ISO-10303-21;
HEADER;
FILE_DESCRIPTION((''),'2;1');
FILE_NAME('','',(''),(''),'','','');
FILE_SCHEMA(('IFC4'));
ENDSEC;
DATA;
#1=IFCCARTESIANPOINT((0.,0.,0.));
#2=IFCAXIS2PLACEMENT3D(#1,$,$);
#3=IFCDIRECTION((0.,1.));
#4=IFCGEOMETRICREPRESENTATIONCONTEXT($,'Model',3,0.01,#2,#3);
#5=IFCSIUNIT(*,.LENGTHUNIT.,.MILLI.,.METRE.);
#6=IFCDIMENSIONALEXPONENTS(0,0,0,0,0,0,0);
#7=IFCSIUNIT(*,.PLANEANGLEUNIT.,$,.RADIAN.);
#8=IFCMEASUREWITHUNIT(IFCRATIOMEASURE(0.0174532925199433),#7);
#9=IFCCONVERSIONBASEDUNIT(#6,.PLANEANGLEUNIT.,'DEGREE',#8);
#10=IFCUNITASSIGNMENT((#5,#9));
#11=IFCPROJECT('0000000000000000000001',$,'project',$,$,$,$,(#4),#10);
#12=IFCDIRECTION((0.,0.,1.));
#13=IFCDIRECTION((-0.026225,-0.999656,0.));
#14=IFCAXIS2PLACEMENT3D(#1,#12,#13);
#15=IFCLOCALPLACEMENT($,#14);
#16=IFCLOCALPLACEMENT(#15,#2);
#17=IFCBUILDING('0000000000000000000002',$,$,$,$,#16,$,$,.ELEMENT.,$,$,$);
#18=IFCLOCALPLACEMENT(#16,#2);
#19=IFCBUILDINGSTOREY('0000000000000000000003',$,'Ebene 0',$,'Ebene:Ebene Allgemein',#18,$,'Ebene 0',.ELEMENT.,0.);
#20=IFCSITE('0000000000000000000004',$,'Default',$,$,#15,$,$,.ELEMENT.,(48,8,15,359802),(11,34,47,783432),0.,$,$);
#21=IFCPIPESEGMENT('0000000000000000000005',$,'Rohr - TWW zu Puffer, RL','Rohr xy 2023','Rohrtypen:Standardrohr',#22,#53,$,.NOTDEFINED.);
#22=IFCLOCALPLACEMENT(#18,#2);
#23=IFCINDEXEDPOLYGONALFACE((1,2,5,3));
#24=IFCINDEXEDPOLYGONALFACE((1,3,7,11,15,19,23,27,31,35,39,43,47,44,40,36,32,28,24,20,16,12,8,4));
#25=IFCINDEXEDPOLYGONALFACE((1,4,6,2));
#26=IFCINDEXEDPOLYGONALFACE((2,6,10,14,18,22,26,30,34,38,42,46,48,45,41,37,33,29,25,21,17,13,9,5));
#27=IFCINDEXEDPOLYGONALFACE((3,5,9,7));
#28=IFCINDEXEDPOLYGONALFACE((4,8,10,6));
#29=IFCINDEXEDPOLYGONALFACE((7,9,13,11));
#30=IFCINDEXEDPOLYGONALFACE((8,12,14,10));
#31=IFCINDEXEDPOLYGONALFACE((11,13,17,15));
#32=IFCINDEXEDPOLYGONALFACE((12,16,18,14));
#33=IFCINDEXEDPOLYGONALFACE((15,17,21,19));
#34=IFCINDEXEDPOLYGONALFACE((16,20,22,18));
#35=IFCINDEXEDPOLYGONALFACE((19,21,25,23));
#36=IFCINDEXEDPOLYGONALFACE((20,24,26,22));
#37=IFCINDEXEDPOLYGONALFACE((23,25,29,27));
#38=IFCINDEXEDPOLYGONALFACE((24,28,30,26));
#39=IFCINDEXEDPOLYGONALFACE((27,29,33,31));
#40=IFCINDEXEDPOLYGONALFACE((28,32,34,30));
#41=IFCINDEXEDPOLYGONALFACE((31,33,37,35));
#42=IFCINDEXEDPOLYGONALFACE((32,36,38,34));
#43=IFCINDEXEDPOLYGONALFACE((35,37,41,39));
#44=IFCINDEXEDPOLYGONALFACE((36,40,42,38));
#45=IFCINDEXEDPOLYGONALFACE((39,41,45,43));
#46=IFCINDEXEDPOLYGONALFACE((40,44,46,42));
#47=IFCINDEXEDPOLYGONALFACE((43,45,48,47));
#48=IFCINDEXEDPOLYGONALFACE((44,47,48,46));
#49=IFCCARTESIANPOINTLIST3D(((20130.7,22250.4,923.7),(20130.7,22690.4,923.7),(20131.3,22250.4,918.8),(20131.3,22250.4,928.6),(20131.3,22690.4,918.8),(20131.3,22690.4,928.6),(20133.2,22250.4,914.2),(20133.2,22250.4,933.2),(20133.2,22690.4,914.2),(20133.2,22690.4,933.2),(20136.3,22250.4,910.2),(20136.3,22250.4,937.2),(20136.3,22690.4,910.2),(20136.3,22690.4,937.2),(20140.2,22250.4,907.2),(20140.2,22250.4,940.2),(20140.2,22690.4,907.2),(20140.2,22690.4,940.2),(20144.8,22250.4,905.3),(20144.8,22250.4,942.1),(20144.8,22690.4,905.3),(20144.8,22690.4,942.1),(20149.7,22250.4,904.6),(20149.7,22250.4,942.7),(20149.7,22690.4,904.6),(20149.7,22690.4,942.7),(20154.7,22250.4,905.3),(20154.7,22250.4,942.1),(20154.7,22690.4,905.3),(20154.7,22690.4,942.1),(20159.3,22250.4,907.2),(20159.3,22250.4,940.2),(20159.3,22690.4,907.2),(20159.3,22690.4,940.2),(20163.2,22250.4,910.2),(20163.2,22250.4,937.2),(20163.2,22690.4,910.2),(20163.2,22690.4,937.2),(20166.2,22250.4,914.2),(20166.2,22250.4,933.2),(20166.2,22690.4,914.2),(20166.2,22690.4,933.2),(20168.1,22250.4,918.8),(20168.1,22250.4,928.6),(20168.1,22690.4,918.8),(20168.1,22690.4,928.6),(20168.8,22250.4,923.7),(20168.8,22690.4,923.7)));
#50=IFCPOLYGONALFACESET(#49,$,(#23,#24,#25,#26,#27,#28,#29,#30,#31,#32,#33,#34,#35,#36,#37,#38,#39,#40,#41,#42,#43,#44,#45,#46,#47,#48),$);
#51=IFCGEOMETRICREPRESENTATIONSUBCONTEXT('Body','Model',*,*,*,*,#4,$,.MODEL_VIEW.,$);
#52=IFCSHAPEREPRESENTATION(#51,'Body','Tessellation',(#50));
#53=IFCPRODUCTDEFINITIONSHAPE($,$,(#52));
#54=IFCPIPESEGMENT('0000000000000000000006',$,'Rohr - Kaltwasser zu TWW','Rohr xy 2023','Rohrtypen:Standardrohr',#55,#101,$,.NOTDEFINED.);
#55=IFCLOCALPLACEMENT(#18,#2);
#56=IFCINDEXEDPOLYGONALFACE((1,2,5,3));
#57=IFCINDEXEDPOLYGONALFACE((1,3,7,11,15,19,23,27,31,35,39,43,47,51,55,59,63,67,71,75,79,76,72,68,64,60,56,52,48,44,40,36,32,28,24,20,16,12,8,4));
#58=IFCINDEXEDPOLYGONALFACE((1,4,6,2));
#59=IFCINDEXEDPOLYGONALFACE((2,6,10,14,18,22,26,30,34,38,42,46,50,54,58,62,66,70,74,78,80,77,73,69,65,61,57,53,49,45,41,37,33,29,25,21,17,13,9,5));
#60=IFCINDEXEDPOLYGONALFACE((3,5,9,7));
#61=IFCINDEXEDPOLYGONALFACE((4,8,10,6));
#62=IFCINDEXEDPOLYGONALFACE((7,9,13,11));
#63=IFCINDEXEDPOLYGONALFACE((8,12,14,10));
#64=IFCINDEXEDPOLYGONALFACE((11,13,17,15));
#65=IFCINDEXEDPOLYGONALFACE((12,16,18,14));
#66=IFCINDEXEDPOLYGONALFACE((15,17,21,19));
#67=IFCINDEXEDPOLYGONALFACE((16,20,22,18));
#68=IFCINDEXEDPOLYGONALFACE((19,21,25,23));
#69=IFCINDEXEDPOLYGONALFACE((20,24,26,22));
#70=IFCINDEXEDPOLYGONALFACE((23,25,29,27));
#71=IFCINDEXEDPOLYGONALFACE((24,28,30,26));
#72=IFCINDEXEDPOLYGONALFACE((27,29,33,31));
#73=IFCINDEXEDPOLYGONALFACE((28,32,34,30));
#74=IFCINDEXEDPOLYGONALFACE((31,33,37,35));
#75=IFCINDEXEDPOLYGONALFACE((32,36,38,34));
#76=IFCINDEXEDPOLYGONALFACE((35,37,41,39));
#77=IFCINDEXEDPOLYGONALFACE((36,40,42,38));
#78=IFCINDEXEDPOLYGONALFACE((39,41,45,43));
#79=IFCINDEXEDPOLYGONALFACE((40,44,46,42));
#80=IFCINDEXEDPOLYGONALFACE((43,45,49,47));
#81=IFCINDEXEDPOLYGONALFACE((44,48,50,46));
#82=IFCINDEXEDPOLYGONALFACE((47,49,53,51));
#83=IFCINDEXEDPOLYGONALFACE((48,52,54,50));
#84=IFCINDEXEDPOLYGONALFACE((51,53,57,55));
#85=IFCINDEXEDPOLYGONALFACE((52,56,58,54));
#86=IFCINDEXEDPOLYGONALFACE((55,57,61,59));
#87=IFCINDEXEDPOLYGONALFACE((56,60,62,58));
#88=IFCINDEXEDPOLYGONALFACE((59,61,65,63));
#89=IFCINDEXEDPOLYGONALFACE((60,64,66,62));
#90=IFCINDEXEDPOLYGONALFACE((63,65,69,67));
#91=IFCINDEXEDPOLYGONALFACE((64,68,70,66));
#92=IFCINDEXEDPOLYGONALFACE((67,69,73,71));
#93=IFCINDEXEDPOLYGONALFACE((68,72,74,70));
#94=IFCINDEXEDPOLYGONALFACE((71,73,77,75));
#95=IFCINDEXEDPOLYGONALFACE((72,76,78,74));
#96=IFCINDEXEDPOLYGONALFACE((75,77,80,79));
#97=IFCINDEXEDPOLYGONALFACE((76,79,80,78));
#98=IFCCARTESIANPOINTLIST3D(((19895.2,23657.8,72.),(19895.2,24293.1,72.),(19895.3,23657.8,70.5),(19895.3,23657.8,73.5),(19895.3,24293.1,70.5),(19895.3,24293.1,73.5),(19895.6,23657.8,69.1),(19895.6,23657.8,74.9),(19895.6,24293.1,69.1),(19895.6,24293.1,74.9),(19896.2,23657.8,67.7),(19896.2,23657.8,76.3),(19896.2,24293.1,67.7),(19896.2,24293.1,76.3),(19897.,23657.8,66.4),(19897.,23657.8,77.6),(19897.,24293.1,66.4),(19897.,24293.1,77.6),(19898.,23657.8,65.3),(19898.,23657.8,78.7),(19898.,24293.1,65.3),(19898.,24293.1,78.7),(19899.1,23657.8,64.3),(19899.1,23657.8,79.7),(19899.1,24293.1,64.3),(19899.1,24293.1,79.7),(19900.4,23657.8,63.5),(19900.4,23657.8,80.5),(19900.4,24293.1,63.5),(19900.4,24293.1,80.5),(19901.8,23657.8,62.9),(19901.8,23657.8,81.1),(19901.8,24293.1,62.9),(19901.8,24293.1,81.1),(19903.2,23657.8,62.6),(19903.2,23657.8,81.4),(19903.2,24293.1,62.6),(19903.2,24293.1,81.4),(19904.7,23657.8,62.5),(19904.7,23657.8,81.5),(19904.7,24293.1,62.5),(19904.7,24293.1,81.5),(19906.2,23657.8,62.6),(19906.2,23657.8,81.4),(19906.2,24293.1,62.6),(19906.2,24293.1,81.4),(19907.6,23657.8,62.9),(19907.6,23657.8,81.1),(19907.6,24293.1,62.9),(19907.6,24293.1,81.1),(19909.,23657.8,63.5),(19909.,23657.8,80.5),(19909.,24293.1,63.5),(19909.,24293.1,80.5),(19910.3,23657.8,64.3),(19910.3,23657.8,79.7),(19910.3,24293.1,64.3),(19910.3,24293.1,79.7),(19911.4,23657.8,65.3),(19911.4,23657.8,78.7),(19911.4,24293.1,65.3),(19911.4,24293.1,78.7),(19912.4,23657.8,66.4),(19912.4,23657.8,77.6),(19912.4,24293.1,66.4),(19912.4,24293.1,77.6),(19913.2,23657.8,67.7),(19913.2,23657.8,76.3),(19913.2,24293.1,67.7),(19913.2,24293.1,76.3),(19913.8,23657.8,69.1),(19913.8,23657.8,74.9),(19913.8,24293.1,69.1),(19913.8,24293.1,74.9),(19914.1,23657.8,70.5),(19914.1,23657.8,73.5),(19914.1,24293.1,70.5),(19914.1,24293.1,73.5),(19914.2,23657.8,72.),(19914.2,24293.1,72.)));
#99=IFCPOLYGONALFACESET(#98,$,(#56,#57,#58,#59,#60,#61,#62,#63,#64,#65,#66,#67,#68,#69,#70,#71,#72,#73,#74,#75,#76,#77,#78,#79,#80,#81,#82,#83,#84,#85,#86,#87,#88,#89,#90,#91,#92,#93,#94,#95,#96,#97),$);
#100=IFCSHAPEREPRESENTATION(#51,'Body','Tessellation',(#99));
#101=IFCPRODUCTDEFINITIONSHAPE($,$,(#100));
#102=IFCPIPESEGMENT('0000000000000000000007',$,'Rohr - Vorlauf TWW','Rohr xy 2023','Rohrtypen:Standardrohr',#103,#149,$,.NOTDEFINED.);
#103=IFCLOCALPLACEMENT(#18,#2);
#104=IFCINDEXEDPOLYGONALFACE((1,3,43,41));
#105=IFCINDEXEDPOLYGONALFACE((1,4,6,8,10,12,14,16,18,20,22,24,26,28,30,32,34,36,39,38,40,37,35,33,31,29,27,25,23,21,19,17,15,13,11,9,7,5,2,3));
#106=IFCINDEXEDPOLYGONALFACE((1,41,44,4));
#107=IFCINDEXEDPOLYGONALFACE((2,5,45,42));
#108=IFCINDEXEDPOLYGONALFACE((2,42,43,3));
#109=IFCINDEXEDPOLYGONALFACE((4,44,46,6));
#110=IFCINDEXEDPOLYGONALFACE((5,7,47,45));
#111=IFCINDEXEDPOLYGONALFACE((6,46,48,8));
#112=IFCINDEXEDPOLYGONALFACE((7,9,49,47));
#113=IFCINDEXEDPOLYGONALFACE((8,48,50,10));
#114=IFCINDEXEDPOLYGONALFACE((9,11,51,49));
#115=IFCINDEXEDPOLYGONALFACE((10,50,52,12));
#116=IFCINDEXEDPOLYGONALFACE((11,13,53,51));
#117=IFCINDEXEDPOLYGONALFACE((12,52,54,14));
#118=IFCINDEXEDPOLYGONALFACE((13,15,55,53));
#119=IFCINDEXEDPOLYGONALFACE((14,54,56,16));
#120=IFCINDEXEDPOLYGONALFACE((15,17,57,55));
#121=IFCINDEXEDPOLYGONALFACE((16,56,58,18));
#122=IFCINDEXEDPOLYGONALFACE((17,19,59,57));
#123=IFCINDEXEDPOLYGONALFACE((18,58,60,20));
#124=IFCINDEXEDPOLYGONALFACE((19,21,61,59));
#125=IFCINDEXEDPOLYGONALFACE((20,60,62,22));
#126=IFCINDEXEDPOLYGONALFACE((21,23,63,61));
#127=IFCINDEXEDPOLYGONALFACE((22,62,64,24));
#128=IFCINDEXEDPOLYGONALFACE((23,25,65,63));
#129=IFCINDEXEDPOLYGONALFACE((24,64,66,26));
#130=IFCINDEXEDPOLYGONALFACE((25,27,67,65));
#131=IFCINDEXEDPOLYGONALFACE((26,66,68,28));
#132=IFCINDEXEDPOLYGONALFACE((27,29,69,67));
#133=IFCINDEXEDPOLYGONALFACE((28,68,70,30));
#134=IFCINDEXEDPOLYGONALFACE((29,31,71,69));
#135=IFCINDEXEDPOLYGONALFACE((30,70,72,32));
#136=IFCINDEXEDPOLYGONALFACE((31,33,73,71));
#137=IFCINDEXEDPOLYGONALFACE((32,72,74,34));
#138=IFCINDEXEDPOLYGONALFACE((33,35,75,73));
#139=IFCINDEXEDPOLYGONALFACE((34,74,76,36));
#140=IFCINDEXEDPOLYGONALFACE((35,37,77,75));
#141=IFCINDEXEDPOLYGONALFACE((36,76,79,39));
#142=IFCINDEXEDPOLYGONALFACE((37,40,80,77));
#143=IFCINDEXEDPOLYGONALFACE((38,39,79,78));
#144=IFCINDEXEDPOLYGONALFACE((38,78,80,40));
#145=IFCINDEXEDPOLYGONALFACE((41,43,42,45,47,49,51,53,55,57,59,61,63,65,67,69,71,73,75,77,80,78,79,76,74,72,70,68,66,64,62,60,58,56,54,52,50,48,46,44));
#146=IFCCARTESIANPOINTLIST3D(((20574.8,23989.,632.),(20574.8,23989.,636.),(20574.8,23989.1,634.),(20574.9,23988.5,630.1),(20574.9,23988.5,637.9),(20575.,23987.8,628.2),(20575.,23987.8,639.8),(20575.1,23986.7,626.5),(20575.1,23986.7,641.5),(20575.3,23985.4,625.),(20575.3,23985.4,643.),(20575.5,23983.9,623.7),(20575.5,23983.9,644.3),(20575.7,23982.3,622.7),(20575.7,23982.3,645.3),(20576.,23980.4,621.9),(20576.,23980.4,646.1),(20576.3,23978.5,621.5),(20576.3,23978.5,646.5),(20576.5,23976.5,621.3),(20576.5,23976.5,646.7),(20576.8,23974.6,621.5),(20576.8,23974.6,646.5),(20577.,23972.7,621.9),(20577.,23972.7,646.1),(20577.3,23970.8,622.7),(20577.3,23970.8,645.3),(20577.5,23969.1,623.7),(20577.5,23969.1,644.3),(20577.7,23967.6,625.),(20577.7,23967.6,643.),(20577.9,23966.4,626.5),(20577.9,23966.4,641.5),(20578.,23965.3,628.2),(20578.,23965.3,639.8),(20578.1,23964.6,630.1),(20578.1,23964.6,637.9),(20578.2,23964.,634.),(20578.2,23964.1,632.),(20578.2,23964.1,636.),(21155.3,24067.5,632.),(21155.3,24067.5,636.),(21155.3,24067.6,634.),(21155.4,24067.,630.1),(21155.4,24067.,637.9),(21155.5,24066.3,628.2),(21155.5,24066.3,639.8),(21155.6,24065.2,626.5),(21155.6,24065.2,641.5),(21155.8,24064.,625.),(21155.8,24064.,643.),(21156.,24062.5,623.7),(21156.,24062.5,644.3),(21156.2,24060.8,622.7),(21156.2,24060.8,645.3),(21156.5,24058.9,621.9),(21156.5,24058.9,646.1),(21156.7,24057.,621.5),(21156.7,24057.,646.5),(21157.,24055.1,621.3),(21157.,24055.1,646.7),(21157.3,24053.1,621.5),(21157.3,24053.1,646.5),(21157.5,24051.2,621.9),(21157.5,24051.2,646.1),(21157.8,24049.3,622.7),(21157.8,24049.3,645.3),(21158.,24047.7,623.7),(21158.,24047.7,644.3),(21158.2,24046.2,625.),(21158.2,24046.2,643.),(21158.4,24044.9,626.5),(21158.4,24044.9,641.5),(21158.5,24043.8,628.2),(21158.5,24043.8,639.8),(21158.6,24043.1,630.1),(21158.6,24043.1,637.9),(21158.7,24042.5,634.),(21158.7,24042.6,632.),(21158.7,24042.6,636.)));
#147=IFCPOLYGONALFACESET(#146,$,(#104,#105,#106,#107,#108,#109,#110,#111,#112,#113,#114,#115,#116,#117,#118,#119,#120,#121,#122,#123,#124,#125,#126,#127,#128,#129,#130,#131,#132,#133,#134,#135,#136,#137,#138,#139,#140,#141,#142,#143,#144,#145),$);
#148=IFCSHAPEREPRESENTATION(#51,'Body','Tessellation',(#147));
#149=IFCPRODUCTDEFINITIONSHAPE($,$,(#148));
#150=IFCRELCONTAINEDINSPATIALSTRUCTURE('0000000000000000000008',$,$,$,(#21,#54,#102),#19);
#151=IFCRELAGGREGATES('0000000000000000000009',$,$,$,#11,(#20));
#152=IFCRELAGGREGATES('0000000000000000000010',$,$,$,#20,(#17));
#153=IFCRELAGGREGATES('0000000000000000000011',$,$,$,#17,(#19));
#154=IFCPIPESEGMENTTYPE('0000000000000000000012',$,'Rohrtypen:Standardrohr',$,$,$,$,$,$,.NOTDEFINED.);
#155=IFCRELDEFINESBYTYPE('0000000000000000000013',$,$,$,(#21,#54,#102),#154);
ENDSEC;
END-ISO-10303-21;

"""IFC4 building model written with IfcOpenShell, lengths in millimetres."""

from ifc_helpers import new_model, entity, si_unit, converted_unit, direction, frame, origin, place, context, subcontext, project, spatial, indexed_curve, outline, extrude, type_object, element, save


model = new_model("IFC4")

# Units and contexts
model_context = context("Model", 3, precision=0.01, world=origin(), true_north=direction((0.0, 1.0)))
body_context = subcontext(model_context, "Body", "Model", "MODEL_VIEW")
ifc_project = project(units=[si_unit("LENGTHUNIT", "METRE", prefix="MILLI"), converted_unit("PLANEANGLEUNIT", "DEGREE", entity("IfcRatioMeasure", 0.0174532925199433), si_unit("PLANEANGLEUNIT", "RADIAN"), dimensions=[0, 0, 0, 0, 0, 0, 0])], contexts=[model_context])

# Site, building, storey
site_placement = place(None, frame((0.0, 0.0, 0.0), z_axis=(0.0, 0.0, 1.0), x_axis=(-0.026225, -0.999656, 0.0)))
site = spatial("IfcSite", under=ifc_project, at=site_placement, Name="Default", CompositionType="ELEMENT", RefLatitude=(48, 8, 15, 359802), RefLongitude=(11, 34, 47, 783432), RefElevation=0.0)
building_placement = place(site_placement, origin())
building = spatial("IfcBuilding", under=site, at=building_placement, CompositionType="ELEMENT")
storey_placement = place(building_placement, origin())
storey = spatial("IfcBuildingStorey", under=building, at=storey_placement, Name="Ebene 0", ObjectType="Ebene:Ebene Allgemein", LongName="Ebene 0", CompositionType="ELEMENT", Elevation=0.0)

# Pipe segments
pipe_segment_type = type_object("IfcPipeSegmentType", Name="Rohrtypen:Standardrohr", PredefinedType="NOTDEFINED")
pipe_segment_1_placement = place(storey_placement, origin())
element("IfcPipeSegment", 1, at=pipe_segment_1_placement, inside=storey, type_object=pipe_segment_type, Name="Rohr - TWW zu Puffer, RL", Description="Rohr xy 2023", ObjectType="Rohrtypen:Standardrohr", PredefinedType="NOTDEFINED", context=body_context, shape_type="SweptSolid", body=[
    extrude(outline(indexed_curve([(-2.5, -18.9), (2.5, -18.9), (7.3, -17.6), (11.6, -15.1), (15.1, -11.6), (17.6, -7.3), (18.9, -2.5), (18.9, 2.5), (17.6, 7.3), (15.1, 11.6), (11.6, 15.1), (7.3, 17.6), (2.5, 18.9), (-2.5, 18.9), (-7.3, 17.6), (-11.6, 15.1), (-15.1, 11.6), (-17.6, 7.3), (-18.9, 2.5), (-18.9, -2.5), (-17.6, -7.3), (-15.1, -11.6), (-11.6, -15.1), (-7.3, -17.6), (-2.5, -18.9)], self_intersect=False)), frame((20149.7, 22250.4, 923.7), z_axis=(0.0, 1.0, 0.0), x_axis=(0.130526, 0.0, 0.991445)), (0.0, 0.0, 1.0), 440.0),
])
pipe_segment_2_placement = place(storey_placement, origin())
element("IfcPipeSegment", 2, at=pipe_segment_2_placement, inside=storey, type_object=pipe_segment_type, Name="Rohr - Kaltwasser zu TWW", Description="Rohr xy 2023", ObjectType="Rohrtypen:Standardrohr", PredefinedType="NOTDEFINED", context=body_context, shape_type="SweptSolid", body=[
    extrude(outline(indexed_curve([(9.5, 0.0), (9.4, 1.5), (9.1, 2.9), (8.5, 4.3), (7.7, 5.6), (6.7, 6.7), (5.6, 7.7), (4.3, 8.5), (2.9, 9.1), (1.5, 9.4), (0.0, 9.5), (-1.5, 9.4), (-2.9, 9.1), (-4.3, 8.5), (-5.6, 7.7), (-6.7, 6.7), (-7.7, 5.6), (-8.5, 4.3), (-9.1, 2.9), (-9.4, 1.5), (-9.5, 0.0), (-9.4, -1.5), (-9.1, -2.9), (-8.5, -4.3), (-7.7, -5.6), (-6.7, -6.7), (-5.6, -7.7), (-4.3, -8.5), (-2.9, -9.1), (-1.5, -9.4), (0.0, -9.5), (1.5, -9.4), (2.9, -9.1), (4.3, -8.5), (5.6, -7.7), (6.7, -6.7), (7.7, -5.6), (8.5, -4.3), (9.1, -2.9), (9.4, -1.5), (9.5, 0.0)], self_intersect=False)), frame((19904.7, 23657.8, 72.0), z_axis=(0.0, 1.0, 0.0), x_axis=(1.0, 0.0, 0.0)), (0.0, 0.0, 1.0), 635.3),
])
pipe_segment_3_placement = place(storey_placement, origin())
element("IfcPipeSegment", 3, at=pipe_segment_3_placement, inside=storey, type_object=pipe_segment_type, Name="Rohr - Vorlauf TWW", Description="Rohr xy 2023", ObjectType="Rohrtypen:Standardrohr", PredefinedType="NOTDEFINED", context=body_context, shape_type="SweptSolid", body=[
    extrude(outline(indexed_curve([(12.7, 0.0), (12.5, 2.0), (12.1, 3.9), (11.3, 5.8), (10.3, 7.5), (9.0, 9.0), (7.5, 10.3), (5.8, 11.3), (3.9, 12.1), (2.0, 12.5), (0.0, 12.7), (-2.0, 12.5), (-3.9, 12.1), (-5.8, 11.3), (-7.5, 10.3), (-9.0, 9.0), (-10.3, 7.5), (-11.3, 5.8), (-12.1, 3.9), (-12.5, 2.0), (-12.7, 0.0), (-12.5, -2.0), (-12.1, -3.9), (-11.3, -5.8), (-10.3, -7.5), (-9.0, -9.0), (-7.5, -10.3), (-5.8, -11.3), (-3.9, -12.1), (-2.0, -12.5), (0.0, -12.7), (2.0, -12.5), (3.9, -12.1), (5.8, -11.3), (7.5, -10.3), (9.0, -9.0), (10.3, -7.5), (11.3, -5.8), (12.1, -3.9), (12.5, -2.0), (12.7, 0.0)], self_intersect=False)), frame((20576.5, 23976.5, 634.0), z_axis=(0.990977, 0.134035, 0.0), x_axis=(0.134035, -0.990977, 0.0)), (0.0, 0.0, 1.0), 585.8),
])

save(model, "model.ifc")
